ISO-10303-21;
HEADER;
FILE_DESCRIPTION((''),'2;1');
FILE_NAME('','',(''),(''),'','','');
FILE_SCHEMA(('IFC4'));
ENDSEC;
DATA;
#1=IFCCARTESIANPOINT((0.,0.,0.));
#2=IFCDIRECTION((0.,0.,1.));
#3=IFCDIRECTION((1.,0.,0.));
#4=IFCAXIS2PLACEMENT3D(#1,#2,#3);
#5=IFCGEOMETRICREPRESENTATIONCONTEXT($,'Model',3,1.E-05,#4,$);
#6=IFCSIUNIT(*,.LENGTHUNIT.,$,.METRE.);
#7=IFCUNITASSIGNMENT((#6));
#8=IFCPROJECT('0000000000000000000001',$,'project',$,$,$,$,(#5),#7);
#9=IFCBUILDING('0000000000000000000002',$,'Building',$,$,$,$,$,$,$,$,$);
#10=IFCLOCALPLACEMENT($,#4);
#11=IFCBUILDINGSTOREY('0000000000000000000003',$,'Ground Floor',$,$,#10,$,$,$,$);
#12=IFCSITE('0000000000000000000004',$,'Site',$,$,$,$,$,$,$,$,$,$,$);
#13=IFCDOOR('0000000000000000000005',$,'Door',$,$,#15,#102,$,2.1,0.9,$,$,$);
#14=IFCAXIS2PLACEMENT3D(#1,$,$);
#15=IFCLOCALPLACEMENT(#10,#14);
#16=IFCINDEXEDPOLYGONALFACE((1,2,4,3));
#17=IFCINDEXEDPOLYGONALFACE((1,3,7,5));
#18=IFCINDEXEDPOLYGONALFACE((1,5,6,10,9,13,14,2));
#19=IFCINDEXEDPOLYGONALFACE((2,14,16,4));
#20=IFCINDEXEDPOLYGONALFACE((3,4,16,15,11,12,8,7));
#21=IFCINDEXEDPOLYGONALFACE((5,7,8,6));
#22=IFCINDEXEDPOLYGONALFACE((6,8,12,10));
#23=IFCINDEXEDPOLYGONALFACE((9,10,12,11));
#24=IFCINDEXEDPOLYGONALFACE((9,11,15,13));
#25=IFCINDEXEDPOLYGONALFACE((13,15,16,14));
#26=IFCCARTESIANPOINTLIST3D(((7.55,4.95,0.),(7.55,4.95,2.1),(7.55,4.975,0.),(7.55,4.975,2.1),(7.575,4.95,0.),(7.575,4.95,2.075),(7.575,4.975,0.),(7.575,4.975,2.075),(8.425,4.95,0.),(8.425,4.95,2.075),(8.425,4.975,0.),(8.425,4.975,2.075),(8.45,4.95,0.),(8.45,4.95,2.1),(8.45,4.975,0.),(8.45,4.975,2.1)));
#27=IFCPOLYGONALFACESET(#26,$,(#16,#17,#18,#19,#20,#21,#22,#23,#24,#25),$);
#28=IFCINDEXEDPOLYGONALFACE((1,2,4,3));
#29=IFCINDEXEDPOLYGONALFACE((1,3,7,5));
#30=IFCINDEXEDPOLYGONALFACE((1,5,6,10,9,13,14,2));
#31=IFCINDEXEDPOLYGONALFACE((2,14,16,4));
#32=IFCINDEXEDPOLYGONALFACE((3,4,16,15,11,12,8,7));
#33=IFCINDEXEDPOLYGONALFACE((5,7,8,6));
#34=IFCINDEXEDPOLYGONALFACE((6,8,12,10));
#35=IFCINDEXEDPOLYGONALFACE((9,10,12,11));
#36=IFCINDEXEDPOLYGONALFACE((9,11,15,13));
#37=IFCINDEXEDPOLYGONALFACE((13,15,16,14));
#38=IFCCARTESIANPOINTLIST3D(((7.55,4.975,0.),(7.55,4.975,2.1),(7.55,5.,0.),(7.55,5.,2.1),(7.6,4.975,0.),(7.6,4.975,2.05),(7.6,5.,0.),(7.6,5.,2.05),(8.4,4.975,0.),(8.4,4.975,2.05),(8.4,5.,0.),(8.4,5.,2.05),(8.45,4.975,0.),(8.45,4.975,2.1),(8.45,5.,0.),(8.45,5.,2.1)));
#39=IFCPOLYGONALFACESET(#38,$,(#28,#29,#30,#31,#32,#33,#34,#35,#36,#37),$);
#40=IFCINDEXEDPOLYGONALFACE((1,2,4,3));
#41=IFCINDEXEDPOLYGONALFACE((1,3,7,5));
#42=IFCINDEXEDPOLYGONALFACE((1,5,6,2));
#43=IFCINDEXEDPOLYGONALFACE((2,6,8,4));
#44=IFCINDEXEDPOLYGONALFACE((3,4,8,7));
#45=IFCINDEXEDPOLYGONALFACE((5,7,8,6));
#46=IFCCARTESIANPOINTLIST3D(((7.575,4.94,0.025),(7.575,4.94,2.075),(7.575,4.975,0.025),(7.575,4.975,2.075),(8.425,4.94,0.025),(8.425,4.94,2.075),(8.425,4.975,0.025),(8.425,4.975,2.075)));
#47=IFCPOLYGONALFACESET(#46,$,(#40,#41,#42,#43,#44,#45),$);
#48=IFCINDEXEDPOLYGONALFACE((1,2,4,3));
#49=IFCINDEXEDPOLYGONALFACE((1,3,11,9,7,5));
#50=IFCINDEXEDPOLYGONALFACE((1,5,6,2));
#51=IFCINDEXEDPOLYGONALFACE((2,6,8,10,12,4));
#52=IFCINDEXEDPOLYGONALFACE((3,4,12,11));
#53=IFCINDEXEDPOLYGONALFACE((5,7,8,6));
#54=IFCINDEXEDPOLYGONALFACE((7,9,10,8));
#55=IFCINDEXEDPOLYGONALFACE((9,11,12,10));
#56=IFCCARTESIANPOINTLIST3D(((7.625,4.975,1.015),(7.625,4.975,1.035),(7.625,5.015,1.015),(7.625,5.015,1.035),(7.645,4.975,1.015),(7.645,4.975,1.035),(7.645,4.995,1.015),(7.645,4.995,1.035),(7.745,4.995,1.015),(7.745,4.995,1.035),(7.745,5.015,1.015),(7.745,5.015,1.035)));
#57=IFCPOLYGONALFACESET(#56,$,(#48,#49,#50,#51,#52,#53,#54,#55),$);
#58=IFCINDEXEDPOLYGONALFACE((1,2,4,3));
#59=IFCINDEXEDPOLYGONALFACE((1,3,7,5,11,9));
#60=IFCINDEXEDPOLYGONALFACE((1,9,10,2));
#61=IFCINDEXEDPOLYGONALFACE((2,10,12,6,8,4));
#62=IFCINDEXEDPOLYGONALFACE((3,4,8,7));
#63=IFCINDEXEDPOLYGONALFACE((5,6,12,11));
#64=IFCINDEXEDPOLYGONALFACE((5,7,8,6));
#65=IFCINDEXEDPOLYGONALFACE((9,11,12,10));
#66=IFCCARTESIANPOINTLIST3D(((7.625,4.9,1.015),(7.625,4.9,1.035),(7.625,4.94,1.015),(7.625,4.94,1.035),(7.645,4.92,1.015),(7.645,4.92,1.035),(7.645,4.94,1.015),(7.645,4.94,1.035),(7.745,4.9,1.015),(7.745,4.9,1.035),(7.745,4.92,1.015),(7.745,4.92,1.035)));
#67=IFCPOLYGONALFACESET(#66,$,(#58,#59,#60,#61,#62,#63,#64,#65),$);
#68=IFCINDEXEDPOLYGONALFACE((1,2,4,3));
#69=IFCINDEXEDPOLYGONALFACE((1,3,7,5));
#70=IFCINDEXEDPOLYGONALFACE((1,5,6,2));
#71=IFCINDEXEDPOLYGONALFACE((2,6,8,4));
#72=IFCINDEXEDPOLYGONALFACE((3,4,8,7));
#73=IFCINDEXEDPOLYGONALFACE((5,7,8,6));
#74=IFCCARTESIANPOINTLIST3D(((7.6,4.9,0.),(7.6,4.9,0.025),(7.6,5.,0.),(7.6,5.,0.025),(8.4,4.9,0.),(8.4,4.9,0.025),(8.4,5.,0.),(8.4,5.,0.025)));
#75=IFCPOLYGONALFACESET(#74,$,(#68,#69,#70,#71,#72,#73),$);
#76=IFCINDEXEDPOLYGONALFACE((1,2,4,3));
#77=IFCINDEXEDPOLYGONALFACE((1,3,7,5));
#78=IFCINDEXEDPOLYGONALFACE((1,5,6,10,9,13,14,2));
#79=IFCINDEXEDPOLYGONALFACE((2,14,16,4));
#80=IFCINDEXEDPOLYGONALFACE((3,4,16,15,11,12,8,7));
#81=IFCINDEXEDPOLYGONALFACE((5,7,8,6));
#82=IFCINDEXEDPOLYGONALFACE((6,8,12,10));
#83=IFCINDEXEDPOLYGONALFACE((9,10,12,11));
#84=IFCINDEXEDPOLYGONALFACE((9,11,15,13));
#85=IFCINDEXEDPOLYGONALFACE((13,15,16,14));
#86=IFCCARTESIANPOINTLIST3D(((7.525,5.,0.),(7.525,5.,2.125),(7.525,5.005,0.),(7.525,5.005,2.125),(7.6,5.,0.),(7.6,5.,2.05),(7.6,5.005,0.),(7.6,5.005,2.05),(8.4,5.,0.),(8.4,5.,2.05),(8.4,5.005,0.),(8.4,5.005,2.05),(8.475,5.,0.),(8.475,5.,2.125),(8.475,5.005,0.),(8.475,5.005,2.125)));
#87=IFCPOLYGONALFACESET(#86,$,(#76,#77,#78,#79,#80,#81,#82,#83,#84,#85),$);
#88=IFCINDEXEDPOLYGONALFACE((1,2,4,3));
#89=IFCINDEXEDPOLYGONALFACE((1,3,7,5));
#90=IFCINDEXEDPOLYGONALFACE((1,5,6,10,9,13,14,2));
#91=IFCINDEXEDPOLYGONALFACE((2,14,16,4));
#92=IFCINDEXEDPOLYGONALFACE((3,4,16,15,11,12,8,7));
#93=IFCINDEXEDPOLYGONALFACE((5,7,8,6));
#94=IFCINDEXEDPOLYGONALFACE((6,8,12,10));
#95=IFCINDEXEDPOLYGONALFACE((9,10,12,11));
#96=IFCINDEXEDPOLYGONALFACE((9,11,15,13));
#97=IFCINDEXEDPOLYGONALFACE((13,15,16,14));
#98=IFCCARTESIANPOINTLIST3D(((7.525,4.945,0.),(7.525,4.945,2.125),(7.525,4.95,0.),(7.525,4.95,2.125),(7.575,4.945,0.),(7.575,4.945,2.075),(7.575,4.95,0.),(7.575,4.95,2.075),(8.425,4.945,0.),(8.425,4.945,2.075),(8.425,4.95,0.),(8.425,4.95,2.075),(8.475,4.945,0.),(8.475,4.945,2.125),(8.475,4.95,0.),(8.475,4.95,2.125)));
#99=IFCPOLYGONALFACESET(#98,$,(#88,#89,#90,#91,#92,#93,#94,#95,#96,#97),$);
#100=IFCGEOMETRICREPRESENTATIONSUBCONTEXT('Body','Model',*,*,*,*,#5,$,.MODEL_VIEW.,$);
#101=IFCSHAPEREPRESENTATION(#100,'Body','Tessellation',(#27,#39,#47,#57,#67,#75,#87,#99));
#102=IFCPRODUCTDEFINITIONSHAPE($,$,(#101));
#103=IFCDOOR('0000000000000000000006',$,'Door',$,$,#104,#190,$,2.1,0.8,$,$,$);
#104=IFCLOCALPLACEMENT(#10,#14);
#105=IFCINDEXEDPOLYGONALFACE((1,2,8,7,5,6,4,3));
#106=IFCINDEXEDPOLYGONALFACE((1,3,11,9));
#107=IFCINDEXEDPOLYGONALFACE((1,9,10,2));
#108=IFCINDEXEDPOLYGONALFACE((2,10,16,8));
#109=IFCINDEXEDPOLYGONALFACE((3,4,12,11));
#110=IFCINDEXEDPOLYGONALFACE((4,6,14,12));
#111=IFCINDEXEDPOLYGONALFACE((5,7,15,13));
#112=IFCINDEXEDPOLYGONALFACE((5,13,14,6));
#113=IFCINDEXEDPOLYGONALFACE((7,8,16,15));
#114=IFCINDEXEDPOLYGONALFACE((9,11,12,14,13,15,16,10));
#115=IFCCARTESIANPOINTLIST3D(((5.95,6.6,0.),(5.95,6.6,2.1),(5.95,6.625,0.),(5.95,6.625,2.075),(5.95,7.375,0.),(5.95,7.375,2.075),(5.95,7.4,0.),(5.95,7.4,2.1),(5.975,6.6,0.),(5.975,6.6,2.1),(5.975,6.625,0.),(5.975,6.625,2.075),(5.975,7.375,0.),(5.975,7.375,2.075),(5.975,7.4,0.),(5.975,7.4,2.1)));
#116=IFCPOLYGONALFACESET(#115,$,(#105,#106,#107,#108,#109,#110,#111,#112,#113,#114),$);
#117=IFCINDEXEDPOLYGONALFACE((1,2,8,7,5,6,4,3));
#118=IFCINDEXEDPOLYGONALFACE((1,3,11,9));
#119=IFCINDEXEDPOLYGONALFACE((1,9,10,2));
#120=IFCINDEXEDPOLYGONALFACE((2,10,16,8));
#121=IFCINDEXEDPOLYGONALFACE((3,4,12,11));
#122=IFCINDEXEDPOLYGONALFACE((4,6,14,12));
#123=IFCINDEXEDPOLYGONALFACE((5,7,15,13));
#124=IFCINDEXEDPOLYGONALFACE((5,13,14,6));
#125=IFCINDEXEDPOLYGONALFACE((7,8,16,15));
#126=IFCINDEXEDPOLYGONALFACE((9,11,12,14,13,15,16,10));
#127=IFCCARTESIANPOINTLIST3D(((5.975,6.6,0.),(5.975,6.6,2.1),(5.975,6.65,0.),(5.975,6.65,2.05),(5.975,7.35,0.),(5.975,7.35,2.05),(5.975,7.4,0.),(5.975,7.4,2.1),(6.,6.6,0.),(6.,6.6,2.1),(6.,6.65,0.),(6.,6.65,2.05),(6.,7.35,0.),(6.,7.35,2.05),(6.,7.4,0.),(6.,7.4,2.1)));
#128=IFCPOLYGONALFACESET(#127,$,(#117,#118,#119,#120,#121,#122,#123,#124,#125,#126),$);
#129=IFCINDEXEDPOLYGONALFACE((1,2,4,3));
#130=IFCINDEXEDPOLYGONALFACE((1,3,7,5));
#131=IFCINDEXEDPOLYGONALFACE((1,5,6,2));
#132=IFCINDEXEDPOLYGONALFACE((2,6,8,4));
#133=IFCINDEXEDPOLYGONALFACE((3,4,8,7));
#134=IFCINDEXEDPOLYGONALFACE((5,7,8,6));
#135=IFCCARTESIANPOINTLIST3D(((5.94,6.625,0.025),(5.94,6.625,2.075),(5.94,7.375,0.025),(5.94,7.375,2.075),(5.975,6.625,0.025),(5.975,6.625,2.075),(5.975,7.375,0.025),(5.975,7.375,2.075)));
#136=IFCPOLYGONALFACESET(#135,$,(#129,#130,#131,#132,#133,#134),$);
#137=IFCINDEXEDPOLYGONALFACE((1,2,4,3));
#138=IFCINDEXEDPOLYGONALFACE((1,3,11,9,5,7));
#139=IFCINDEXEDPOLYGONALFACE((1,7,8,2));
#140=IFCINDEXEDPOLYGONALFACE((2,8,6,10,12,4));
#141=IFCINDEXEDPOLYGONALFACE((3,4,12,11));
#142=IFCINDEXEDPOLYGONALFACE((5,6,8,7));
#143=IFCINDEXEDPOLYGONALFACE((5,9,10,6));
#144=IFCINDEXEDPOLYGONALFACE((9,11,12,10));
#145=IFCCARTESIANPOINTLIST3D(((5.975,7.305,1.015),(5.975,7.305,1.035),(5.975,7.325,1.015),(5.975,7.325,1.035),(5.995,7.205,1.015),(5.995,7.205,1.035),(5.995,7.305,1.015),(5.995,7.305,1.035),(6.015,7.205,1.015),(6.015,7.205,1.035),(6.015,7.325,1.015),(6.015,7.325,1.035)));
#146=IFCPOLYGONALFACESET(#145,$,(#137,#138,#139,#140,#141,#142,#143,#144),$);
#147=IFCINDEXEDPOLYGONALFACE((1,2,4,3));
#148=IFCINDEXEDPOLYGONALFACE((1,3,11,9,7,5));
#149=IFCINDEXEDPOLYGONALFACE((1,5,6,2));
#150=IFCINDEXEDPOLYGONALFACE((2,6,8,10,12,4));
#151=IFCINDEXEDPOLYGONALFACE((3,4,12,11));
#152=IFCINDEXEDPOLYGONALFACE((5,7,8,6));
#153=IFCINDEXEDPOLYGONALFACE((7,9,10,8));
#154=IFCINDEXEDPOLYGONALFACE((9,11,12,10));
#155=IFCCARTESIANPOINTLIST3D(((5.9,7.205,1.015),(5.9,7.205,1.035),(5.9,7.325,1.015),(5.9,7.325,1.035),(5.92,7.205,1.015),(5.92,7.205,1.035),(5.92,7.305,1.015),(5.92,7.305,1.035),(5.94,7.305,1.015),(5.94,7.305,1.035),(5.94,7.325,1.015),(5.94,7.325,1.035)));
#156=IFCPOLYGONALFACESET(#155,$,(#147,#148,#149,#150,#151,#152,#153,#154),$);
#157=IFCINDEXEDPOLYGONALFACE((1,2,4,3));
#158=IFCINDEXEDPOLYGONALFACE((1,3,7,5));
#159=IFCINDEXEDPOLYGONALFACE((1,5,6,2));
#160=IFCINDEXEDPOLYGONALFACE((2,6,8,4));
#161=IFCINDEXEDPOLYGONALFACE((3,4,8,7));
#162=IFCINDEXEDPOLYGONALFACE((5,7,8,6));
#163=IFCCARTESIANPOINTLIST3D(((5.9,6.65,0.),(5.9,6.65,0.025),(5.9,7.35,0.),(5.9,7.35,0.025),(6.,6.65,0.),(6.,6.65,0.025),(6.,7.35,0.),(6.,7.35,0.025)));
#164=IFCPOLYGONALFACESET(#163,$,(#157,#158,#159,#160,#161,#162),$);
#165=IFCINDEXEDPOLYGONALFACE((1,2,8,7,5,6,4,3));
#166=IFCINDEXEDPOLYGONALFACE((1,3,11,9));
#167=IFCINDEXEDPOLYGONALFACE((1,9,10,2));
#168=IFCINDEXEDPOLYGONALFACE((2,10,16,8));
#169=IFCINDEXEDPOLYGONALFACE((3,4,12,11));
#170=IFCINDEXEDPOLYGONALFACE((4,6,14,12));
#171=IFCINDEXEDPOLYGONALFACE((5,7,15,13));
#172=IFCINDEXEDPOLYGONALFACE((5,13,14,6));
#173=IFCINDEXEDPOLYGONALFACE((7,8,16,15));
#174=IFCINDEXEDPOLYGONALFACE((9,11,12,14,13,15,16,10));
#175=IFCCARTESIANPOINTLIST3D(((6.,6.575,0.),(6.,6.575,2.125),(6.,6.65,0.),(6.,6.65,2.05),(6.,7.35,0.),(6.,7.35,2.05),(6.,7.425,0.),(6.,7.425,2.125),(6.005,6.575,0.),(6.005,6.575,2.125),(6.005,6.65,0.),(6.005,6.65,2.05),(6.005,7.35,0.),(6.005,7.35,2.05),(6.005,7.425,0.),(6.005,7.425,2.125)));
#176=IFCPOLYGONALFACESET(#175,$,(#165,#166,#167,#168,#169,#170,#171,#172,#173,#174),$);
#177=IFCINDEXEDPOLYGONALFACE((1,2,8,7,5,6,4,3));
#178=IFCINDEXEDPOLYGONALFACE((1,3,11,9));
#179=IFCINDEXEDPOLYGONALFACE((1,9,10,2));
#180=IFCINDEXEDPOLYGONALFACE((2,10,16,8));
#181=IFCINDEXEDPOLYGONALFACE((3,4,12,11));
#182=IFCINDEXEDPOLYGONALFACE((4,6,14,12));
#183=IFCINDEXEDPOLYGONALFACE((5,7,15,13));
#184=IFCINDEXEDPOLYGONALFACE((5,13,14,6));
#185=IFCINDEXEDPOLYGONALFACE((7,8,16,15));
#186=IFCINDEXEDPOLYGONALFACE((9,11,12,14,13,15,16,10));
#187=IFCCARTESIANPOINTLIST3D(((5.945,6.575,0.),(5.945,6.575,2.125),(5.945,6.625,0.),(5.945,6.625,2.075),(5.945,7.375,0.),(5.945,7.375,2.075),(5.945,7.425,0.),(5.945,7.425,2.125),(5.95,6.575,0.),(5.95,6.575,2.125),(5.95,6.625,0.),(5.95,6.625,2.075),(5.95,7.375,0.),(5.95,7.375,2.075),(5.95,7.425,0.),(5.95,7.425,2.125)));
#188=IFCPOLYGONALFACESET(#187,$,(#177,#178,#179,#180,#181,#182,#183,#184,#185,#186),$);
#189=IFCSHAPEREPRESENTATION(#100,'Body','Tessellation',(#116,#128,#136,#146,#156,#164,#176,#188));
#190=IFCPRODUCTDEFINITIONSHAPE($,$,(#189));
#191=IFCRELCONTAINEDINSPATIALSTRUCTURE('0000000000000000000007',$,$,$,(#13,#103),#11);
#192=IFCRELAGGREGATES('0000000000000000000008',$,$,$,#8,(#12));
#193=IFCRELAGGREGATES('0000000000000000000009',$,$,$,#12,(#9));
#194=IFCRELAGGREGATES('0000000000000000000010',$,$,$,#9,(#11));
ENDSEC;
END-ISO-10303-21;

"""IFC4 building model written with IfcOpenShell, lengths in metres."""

from ifc_helpers import new_model, si_unit, frame, origin_with_axes, place, context, subcontext, project, spatial, line, indexed_curve, outline, extrude, element, save


model = new_model("IFC4")

# Units and contexts
model_context = context("Model", 3, precision=1e-05, world=origin_with_axes())
body_context = subcontext(model_context, "Body", "Model", "MODEL_VIEW")
ifc_project = project(units=[si_unit("LENGTHUNIT", "METRE")], contexts=[model_context])

# Site, building, storey
site = spatial("IfcSite", under=ifc_project, Name="Site")
building = spatial("IfcBuilding", under=site, Name="Building")
storey_placement = place(None, origin_with_axes())
storey = spatial("IfcBuildingStorey", under=building, at=storey_placement, Name="Ground Floor")

# Doors
door_1_placement = place(storey_placement, frame((8.45, 5.0, 0.0), z_axis=(0.0, 0.0, 1.0), x_axis=(-1.0, 0.0, 0.0)))
element("IfcDoor", 1, at=door_1_placement, inside=storey, Name="Door", OverallHeight=2.1, OverallWidth=0.9, context=body_context, shape_type="SweptSolid", body=[
    extrude(outline(indexed_curve([(0.0, 0.0), (0.0, 2.1), (0.9, 2.1), (0.9, 0.0), (0.875, 0.0), (0.875, 2.075), (0.025, 2.075), (0.025, 0.0)], segments=[line(1, 2, 3, 4, 5, 6, 7, 8, 1)])), frame((0.0, 0.025, 0.0), z_axis=(0.0, -1.0, 0.0), x_axis=(1.0, 0.0, 0.0)), (0.0, 0.0, -1.0), 0.025),
    extrude(outline(indexed_curve([(0.0, 0.0), (0.0, 2.1), (0.9, 2.1), (0.9, 0.0), (0.85, 0.0), (0.85, 2.05), (0.05, 2.05), (0.05, 0.0)], segments=[line(1, 2, 3, 4, 5, 6, 7, 8, 1)])), frame((0.0, 0.0, 0.0), z_axis=(0.0, -1.0, 0.0), x_axis=(1.0, 0.0, 0.0)), (0.0, 0.0, -1.0), 0.025),
    extrude(outline(indexed_curve([(0.0, 0.0), (0.85, 0.0), (0.85, 0.035), (0.0, 0.035)], segments=[line(1, 2, 3, 4, 1)])), frame((0.025, 0.025, 0.025), z_axis=(0.0, 0.0, 1.0), x_axis=(1.0, 0.0, 0.0)), (0.0, 0.0, 1.0), 2.05),
    extrude(outline(indexed_curve([(0.0, 0.0), (0.0, -0.04), (-0.12, -0.04), (-0.12, -0.02), (-0.02, -0.02), (-0.02, 0.0)], segments=[line(1, 2, 3, 4, 5, 6, 1)])), frame((0.825, 0.025, 1.015), z_axis=(0.0, 0.0, 1.0), x_axis=(1.0, 0.0, 0.0)), (0.0, 0.0, 1.0), 0.02),
    extrude(outline(indexed_curve([(0.0, 0.0), (0.0, 0.04), (-0.12, 0.04), (-0.12, 0.02), (-0.02, 0.02), (-0.02, 0.0)], segments=[line(1, 2, 3, 4, 5, 6, 1)])), frame((0.825, 0.06, 1.015), z_axis=(0.0, 0.0, 1.0), x_axis=(1.0, 0.0, 0.0)), (0.0, 0.0, 1.0), 0.02),
    extrude(outline(indexed_curve([(0.0, 0.0), (0.8, 0.0), (0.8, 0.1), (0.0, 0.1)], segments=[line(1, 2, 3, 4, 1)])), frame((0.05, 0.0, 0.0), z_axis=(0.0, 0.0, 1.0), x_axis=(1.0, 0.0, 0.0)), (0.0, 0.0, 1.0), 0.025),
    extrude(outline(indexed_curve([(0.0, 0.0), (0.0, 2.125), (0.95, 2.125), (0.95, 0.0), (0.875, 0.0), (0.875, 2.05), (0.075, 2.05), (0.075, 0.0)], segments=[line(1, 2, 3, 4, 5, 6, 7, 8, 1)])), frame((-0.025, -0.005, 0.0), z_axis=(0.0, -1.0, 0.0), x_axis=(1.0, 0.0, 0.0)), (0.0, 0.0, -1.0), 0.005),
    extrude(outline(indexed_curve([(0.0, 0.0), (0.0, 2.125), (0.95, 2.125), (0.95, 0.0), (0.9, 0.0), (0.9, 2.075), (0.05, 2.075), (0.05, 0.0)], segments=[line(1, 2, 3, 4, 5, 6, 7, 8, 1)])), frame((-0.025, 0.05, 0.0), z_axis=(0.0, -1.0, 0.0), x_axis=(1.0, 0.0, 0.0)), (0.0, 0.0, -1.0), 0.005),
])
door_2_placement = place(storey_placement, frame((6.0, 6.6, 0.0), z_axis=(0.0, 0.0, 1.0), x_axis=(0.0, 1.0, 0.0)))
element("IfcDoor", 2, at=door_2_placement, inside=storey, Name="Door", OverallHeight=2.1, OverallWidth=0.8, context=body_context, shape_type="SweptSolid", body=[
    extrude(outline(indexed_curve([(0.0, 0.0), (0.0, 2.1), (0.8, 2.1), (0.8, 0.0), (0.775, 0.0), (0.775, 2.075), (0.025, 2.075), (0.025, 0.0)], segments=[line(1, 2, 3, 4, 5, 6, 7, 8, 1)])), frame((0.0, 0.025, 0.0), z_axis=(0.0, -1.0, 0.0), x_axis=(1.0, 0.0, 0.0)), (0.0, 0.0, -1.0), 0.025),
    extrude(outline(indexed_curve([(0.0, 0.0), (0.0, 2.1), (0.8, 2.1), (0.8, 0.0), (0.75, 0.0), (0.75, 2.05), (0.05, 2.05), (0.05, 0.0)], segments=[line(1, 2, 3, 4, 5, 6, 7, 8, 1)])), frame((0.0, 0.0, 0.0), z_axis=(0.0, -1.0, 0.0), x_axis=(1.0, 0.0, 0.0)), (0.0, 0.0, -1.0), 0.025),
    extrude(outline(indexed_curve([(0.0, 0.0), (0.75, 0.0), (0.75, 0.035), (0.0, 0.035)], segments=[line(1, 2, 3, 4, 1)])), frame((0.025, 0.025, 0.025), z_axis=(0.0, 0.0, 1.0), x_axis=(1.0, 0.0, 0.0)), (0.0, 0.0, 1.0), 2.05),
    extrude(outline(indexed_curve([(0.0, 0.0), (0.0, -0.04), (-0.12, -0.04), (-0.12, -0.02), (-0.02, -0.02), (-0.02, 0.0)], segments=[line(1, 2, 3, 4, 5, 6, 1)])), frame((0.725, 0.025, 1.015), z_axis=(0.0, 0.0, 1.0), x_axis=(1.0, 0.0, 0.0)), (0.0, 0.0, 1.0), 0.02),
    extrude(outline(indexed_curve([(0.0, 0.0), (0.0, 0.04), (-0.12, 0.04), (-0.12, 0.02), (-0.02, 0.02), (-0.02, 0.0)], segments=[line(1, 2, 3, 4, 5, 6, 1)])), frame((0.725, 0.06, 1.015), z_axis=(0.0, 0.0, 1.0), x_axis=(1.0, 0.0, 0.0)), (0.0, 0.0, 1.0), 0.02),
    extrude(outline(indexed_curve([(0.0, 0.0), (0.7, 0.0), (0.7, 0.1), (0.0, 0.1)], segments=[line(1, 2, 3, 4, 1)])), frame((0.05, 0.0, 0.0), z_axis=(0.0, 0.0, 1.0), x_axis=(1.0, 0.0, 0.0)), (0.0, 0.0, 1.0), 0.025),
    extrude(outline(indexed_curve([(0.0, 0.0), (0.0, 2.125), (0.85, 2.125), (0.85, 0.0), (0.775, 0.0), (0.775, 2.05), (0.075, 2.05), (0.075, 0.0)], segments=[line(1, 2, 3, 4, 5, 6, 7, 8, 1)])), frame((-0.025, -0.005, 0.0), z_axis=(0.0, -1.0, 0.0), x_axis=(1.0, 0.0, 0.0)), (0.0, 0.0, -1.0), 0.005),
    extrude(outline(indexed_curve([(0.0, 0.0), (0.0, 2.125), (0.85, 2.125), (0.85, 0.0), (0.8, 0.0), (0.8, 2.075), (0.05, 2.075), (0.05, 0.0)], segments=[line(1, 2, 3, 4, 5, 6, 7, 8, 1)])), frame((-0.025, 0.05, 0.0), z_axis=(0.0, -1.0, 0.0), x_axis=(1.0, 0.0, 0.0)), (0.0, 0.0, -1.0), 0.005),
])

save(model, "model.ifc")
